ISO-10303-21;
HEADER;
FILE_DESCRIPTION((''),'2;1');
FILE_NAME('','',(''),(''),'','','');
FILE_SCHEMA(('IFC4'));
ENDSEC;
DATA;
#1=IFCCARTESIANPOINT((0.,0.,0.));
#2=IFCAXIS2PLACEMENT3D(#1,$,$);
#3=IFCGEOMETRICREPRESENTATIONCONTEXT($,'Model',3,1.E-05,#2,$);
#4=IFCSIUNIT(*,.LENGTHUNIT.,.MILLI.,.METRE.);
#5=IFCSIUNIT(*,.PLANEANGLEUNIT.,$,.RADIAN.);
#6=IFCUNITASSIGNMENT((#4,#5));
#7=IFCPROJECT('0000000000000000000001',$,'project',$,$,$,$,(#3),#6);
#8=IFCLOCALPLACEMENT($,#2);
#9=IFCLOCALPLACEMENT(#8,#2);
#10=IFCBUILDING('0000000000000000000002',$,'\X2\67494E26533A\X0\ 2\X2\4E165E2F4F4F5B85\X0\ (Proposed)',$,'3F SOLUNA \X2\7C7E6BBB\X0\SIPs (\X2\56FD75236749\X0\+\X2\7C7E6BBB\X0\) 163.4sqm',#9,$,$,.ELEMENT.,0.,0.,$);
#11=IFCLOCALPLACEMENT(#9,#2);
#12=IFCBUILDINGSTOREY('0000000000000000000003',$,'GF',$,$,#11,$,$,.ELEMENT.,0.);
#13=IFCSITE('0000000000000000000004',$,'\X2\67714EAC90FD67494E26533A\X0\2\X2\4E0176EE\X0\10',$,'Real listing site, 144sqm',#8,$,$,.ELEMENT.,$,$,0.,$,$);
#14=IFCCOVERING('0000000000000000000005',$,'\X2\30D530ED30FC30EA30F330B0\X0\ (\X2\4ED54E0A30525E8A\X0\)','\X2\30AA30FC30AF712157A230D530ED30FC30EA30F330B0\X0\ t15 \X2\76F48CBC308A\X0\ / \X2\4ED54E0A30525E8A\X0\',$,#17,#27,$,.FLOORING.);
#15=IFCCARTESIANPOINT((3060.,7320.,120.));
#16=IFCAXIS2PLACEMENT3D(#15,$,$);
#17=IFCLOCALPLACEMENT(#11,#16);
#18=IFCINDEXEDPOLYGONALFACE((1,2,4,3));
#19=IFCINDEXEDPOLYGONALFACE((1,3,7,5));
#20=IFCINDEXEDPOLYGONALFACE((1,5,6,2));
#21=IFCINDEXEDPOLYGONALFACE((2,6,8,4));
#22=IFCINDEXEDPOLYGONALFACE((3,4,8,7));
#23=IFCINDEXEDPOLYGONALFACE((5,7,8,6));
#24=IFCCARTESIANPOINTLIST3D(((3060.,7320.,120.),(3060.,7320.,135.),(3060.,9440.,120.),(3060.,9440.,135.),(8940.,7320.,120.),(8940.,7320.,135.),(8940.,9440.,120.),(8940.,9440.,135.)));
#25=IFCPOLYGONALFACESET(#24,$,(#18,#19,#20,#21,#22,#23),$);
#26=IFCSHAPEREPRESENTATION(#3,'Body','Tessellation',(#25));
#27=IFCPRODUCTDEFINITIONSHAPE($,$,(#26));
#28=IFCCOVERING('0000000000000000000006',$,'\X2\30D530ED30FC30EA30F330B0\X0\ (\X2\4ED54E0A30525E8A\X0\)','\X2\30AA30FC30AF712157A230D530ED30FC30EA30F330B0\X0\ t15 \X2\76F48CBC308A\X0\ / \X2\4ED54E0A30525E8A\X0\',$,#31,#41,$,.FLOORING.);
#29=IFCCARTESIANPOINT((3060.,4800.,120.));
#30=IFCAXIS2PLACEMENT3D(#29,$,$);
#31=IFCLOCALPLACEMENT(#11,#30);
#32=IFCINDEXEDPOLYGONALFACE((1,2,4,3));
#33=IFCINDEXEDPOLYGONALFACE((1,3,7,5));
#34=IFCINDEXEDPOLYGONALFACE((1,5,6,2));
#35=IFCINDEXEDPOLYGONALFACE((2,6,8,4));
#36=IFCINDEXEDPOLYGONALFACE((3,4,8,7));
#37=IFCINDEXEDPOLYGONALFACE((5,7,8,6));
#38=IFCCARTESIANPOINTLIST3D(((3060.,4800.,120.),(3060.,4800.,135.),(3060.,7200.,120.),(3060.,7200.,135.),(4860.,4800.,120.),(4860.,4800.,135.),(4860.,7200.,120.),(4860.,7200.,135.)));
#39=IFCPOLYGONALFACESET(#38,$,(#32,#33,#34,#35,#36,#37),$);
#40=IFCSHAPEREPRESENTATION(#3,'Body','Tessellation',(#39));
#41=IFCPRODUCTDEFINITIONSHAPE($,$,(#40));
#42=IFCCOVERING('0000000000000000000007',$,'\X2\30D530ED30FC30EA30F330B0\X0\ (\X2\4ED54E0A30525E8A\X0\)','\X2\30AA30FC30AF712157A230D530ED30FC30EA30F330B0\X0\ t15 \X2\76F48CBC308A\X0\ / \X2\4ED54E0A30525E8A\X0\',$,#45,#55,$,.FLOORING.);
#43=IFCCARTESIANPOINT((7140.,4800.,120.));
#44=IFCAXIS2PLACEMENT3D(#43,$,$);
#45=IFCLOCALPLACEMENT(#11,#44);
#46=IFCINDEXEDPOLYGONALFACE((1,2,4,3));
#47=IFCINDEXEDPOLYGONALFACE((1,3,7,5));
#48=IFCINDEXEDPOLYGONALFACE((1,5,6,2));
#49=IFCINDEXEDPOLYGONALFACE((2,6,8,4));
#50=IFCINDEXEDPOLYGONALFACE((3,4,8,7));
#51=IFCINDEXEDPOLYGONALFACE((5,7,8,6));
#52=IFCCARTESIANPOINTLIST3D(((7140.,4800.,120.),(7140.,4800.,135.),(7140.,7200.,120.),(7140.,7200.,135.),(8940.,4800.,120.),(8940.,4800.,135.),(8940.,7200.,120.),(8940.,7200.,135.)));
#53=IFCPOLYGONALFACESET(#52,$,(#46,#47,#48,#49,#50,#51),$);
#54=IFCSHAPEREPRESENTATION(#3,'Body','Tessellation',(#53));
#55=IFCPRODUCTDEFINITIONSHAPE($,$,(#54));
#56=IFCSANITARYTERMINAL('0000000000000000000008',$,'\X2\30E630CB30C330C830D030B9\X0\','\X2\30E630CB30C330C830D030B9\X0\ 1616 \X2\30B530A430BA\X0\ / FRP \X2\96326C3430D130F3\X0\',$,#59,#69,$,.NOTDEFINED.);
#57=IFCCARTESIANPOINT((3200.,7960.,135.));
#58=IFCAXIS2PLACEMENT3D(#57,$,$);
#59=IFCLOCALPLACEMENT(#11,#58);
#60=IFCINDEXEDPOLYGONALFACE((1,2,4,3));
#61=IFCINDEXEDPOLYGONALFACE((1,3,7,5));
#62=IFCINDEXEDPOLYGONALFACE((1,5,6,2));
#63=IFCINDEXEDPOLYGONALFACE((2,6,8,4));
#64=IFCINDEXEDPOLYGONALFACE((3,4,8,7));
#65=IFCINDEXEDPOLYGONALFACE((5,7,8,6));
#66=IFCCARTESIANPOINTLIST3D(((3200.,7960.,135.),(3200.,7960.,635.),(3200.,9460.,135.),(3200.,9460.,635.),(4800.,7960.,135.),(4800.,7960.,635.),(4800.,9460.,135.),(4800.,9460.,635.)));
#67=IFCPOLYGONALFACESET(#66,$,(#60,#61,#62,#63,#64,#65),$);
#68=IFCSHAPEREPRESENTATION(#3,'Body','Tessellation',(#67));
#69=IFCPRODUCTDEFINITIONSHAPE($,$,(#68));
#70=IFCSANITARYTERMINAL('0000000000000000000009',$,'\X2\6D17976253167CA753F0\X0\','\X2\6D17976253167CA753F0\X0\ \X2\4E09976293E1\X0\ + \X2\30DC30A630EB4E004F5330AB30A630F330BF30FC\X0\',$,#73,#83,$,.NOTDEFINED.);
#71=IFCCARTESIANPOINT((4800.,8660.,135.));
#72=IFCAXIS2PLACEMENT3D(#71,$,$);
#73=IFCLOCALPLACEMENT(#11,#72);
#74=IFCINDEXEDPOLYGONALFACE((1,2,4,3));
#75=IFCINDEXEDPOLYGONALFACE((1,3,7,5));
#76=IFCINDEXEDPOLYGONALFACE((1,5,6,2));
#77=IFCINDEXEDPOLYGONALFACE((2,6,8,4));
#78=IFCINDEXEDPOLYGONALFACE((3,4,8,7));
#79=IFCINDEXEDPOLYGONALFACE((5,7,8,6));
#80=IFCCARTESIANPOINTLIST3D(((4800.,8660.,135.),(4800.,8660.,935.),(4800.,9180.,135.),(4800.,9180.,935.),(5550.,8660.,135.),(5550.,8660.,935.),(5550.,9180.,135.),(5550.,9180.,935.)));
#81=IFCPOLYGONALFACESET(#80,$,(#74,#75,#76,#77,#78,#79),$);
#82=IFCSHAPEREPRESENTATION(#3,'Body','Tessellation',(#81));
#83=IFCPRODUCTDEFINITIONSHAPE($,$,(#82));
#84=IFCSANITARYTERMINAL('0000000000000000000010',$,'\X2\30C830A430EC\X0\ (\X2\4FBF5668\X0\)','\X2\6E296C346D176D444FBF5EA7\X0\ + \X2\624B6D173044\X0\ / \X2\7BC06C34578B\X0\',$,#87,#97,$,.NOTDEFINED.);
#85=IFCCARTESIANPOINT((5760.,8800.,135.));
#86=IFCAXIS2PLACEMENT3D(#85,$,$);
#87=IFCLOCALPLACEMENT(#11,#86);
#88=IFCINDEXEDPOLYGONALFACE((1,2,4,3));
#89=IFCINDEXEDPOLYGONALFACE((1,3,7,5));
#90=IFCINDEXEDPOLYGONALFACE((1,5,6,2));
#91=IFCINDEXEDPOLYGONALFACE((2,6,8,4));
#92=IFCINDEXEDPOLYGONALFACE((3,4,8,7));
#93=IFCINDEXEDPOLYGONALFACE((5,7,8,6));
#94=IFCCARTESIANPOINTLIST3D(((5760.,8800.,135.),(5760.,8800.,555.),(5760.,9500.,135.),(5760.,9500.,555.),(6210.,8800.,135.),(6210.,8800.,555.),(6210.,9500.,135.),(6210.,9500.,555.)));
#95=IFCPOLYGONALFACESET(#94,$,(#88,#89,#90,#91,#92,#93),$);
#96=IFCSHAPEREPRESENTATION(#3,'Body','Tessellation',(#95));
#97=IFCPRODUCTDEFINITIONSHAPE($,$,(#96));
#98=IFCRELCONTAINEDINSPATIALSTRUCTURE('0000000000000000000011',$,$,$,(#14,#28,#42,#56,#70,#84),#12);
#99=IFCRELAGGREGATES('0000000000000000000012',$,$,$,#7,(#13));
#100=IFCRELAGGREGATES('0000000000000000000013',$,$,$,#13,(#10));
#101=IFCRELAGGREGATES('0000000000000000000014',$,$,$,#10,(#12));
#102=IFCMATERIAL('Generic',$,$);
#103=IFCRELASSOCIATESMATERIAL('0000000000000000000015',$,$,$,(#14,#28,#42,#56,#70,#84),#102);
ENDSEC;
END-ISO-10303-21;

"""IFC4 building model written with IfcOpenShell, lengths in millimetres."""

from ifc_helpers import new_model, si_unit, frame, frame_2d, origin, place, context, project, spatial, rectangle, extrude, material, element, save


model = new_model("IFC4")

# Units and contexts
model_context = context("Model", 3, precision=1e-05, world=origin())
ifc_project = project(units=[si_unit("LENGTHUNIT", "METRE", prefix="MILLI"), si_unit("PLANEANGLEUNIT", "RADIAN")], contexts=[model_context])

# Site, building, storey
site_placement = place(None, origin())
site = spatial("IfcSite", under=ifc_project, at=site_placement, Name="東京都杉並区2丁目10", ObjectType="Real listing site, 144sqm", CompositionType="ELEMENT", RefElevation=0.0)
building_placement = place(site_placement, origin())
building = spatial("IfcBuilding", under=site, at=building_placement, Name="杉並区 2世帯住宅 (Proposed)", ObjectType="3F SOLUNA 籾殻SIPs (国産杉+籾殻) 163.4sqm", CompositionType="ELEMENT", ElevationOfRefHeight=0.0, ElevationOfTerrain=0.0)
storey_placement = place(building_placement, origin())
storey = spatial("IfcBuildingStorey", under=building, at=storey_placement, Name="GF", CompositionType="ELEMENT", Elevation=0.0)

# Coverings
ifc_material_1 = material(Name="Generic")
covering_1_placement = place(storey_placement, frame((3060.0, 7320.0, 120.0)))
element("IfcCovering", 1, at=covering_1_placement, inside=storey, material=ifc_material_1, Name="フローリング (仕上げ床)", Description="オーク無垢フローリング t15 直貼り / 仕上げ床", PredefinedType="FLOORING", context=model_context, shape_type="SweptSolid", body=[
    extrude(rectangle(XDim=5880.0, YDim=2120.0, at=frame_2d((2940.0, 1060.0))), frame((3060.0, 7320.0, 120.0)), (0.0, 0.0, 1.0), 15.0),
])
covering_2_placement = place(storey_placement, frame((3060.0, 4800.0, 120.0)))
element("IfcCovering", 2, at=covering_2_placement, inside=storey, material=ifc_material_1, Name="フローリング (仕上げ床)", Description="オーク無垢フローリング t15 直貼り / 仕上げ床", PredefinedType="FLOORING", context=model_context, shape_type="SweptSolid", body=[
    extrude(rectangle(XDim=1800.0, YDim=2400.0, at=frame_2d((900.0, 1200.0))), frame((3060.0, 4800.0, 120.0)), (0.0, 0.0, 1.0), 15.0),
])
covering_3_placement = place(storey_placement, frame((7140.0, 4800.0, 120.0)))
element("IfcCovering", 3, at=covering_3_placement, inside=storey, material=ifc_material_1, Name="フローリング (仕上げ床)", Description="オーク無垢フローリング t15 直貼り / 仕上げ床", PredefinedType="FLOORING", context=model_context, shape_type="SweptSolid", body=[
    extrude(rectangle(XDim=1800.0, YDim=2400.0, at=frame_2d((900.0, 1200.0))), frame((7140.0, 4800.0, 120.0)), (0.0, 0.0, 1.0), 15.0),
])

# Sanitary terminals
sanitary_terminal_1_placement = place(storey_placement, frame((3200.0, 7960.0, 135.0)))
element("IfcSanitaryTerminal", 4, at=sanitary_terminal_1_placement, inside=storey, material=ifc_material_1, Name="ユニットバス", Description="ユニットバス 1616 サイズ / FRP 防水パン", PredefinedType="NOTDEFINED", context=model_context, shape_type="SweptSolid", body=[
    extrude(rectangle(XDim=1600.0, YDim=1500.0, at=frame_2d((800.0, 750.0))), frame((3200.0, 7960.0, 135.0)), (0.0, 0.0, 1.0), 500.0),
])
sanitary_terminal_2_placement = place(storey_placement, frame((4800.0, 8660.0, 135.0)))
element("IfcSanitaryTerminal", 5, at=sanitary_terminal_2_placement, inside=storey, material=ifc_material_1, Name="洗面化粧台", Description="洗面化粧台 三面鏡 + ボウル一体カウンター", PredefinedType="NOTDEFINED", context=model_context, shape_type="SweptSolid", body=[
    extrude(rectangle(XDim=750.0, YDim=520.0, at=frame_2d((375.0, 260.0))), frame((4800.0, 8660.0, 135.0)), (0.0, 0.0, 1.0), 800.0),
])
sanitary_terminal_3_placement = place(storey_placement, frame((5760.0, 8800.0, 135.0)))
element("IfcSanitaryTerminal", 6, at=sanitary_terminal_3_placement, inside=storey, material=ifc_material_1, Name="トイレ (便器)", Description="温水洗浄便座 + 手洗い / 節水型", PredefinedType="NOTDEFINED", context=model_context, shape_type="SweptSolid", body=[
    extrude(rectangle(XDim=450.0, YDim=700.0, at=frame_2d((225.0, 350.0))), frame((5760.0, 8800.0, 135.0)), (0.0, 0.0, 1.0), 420.0),
])

save(model, "model.ifc")
